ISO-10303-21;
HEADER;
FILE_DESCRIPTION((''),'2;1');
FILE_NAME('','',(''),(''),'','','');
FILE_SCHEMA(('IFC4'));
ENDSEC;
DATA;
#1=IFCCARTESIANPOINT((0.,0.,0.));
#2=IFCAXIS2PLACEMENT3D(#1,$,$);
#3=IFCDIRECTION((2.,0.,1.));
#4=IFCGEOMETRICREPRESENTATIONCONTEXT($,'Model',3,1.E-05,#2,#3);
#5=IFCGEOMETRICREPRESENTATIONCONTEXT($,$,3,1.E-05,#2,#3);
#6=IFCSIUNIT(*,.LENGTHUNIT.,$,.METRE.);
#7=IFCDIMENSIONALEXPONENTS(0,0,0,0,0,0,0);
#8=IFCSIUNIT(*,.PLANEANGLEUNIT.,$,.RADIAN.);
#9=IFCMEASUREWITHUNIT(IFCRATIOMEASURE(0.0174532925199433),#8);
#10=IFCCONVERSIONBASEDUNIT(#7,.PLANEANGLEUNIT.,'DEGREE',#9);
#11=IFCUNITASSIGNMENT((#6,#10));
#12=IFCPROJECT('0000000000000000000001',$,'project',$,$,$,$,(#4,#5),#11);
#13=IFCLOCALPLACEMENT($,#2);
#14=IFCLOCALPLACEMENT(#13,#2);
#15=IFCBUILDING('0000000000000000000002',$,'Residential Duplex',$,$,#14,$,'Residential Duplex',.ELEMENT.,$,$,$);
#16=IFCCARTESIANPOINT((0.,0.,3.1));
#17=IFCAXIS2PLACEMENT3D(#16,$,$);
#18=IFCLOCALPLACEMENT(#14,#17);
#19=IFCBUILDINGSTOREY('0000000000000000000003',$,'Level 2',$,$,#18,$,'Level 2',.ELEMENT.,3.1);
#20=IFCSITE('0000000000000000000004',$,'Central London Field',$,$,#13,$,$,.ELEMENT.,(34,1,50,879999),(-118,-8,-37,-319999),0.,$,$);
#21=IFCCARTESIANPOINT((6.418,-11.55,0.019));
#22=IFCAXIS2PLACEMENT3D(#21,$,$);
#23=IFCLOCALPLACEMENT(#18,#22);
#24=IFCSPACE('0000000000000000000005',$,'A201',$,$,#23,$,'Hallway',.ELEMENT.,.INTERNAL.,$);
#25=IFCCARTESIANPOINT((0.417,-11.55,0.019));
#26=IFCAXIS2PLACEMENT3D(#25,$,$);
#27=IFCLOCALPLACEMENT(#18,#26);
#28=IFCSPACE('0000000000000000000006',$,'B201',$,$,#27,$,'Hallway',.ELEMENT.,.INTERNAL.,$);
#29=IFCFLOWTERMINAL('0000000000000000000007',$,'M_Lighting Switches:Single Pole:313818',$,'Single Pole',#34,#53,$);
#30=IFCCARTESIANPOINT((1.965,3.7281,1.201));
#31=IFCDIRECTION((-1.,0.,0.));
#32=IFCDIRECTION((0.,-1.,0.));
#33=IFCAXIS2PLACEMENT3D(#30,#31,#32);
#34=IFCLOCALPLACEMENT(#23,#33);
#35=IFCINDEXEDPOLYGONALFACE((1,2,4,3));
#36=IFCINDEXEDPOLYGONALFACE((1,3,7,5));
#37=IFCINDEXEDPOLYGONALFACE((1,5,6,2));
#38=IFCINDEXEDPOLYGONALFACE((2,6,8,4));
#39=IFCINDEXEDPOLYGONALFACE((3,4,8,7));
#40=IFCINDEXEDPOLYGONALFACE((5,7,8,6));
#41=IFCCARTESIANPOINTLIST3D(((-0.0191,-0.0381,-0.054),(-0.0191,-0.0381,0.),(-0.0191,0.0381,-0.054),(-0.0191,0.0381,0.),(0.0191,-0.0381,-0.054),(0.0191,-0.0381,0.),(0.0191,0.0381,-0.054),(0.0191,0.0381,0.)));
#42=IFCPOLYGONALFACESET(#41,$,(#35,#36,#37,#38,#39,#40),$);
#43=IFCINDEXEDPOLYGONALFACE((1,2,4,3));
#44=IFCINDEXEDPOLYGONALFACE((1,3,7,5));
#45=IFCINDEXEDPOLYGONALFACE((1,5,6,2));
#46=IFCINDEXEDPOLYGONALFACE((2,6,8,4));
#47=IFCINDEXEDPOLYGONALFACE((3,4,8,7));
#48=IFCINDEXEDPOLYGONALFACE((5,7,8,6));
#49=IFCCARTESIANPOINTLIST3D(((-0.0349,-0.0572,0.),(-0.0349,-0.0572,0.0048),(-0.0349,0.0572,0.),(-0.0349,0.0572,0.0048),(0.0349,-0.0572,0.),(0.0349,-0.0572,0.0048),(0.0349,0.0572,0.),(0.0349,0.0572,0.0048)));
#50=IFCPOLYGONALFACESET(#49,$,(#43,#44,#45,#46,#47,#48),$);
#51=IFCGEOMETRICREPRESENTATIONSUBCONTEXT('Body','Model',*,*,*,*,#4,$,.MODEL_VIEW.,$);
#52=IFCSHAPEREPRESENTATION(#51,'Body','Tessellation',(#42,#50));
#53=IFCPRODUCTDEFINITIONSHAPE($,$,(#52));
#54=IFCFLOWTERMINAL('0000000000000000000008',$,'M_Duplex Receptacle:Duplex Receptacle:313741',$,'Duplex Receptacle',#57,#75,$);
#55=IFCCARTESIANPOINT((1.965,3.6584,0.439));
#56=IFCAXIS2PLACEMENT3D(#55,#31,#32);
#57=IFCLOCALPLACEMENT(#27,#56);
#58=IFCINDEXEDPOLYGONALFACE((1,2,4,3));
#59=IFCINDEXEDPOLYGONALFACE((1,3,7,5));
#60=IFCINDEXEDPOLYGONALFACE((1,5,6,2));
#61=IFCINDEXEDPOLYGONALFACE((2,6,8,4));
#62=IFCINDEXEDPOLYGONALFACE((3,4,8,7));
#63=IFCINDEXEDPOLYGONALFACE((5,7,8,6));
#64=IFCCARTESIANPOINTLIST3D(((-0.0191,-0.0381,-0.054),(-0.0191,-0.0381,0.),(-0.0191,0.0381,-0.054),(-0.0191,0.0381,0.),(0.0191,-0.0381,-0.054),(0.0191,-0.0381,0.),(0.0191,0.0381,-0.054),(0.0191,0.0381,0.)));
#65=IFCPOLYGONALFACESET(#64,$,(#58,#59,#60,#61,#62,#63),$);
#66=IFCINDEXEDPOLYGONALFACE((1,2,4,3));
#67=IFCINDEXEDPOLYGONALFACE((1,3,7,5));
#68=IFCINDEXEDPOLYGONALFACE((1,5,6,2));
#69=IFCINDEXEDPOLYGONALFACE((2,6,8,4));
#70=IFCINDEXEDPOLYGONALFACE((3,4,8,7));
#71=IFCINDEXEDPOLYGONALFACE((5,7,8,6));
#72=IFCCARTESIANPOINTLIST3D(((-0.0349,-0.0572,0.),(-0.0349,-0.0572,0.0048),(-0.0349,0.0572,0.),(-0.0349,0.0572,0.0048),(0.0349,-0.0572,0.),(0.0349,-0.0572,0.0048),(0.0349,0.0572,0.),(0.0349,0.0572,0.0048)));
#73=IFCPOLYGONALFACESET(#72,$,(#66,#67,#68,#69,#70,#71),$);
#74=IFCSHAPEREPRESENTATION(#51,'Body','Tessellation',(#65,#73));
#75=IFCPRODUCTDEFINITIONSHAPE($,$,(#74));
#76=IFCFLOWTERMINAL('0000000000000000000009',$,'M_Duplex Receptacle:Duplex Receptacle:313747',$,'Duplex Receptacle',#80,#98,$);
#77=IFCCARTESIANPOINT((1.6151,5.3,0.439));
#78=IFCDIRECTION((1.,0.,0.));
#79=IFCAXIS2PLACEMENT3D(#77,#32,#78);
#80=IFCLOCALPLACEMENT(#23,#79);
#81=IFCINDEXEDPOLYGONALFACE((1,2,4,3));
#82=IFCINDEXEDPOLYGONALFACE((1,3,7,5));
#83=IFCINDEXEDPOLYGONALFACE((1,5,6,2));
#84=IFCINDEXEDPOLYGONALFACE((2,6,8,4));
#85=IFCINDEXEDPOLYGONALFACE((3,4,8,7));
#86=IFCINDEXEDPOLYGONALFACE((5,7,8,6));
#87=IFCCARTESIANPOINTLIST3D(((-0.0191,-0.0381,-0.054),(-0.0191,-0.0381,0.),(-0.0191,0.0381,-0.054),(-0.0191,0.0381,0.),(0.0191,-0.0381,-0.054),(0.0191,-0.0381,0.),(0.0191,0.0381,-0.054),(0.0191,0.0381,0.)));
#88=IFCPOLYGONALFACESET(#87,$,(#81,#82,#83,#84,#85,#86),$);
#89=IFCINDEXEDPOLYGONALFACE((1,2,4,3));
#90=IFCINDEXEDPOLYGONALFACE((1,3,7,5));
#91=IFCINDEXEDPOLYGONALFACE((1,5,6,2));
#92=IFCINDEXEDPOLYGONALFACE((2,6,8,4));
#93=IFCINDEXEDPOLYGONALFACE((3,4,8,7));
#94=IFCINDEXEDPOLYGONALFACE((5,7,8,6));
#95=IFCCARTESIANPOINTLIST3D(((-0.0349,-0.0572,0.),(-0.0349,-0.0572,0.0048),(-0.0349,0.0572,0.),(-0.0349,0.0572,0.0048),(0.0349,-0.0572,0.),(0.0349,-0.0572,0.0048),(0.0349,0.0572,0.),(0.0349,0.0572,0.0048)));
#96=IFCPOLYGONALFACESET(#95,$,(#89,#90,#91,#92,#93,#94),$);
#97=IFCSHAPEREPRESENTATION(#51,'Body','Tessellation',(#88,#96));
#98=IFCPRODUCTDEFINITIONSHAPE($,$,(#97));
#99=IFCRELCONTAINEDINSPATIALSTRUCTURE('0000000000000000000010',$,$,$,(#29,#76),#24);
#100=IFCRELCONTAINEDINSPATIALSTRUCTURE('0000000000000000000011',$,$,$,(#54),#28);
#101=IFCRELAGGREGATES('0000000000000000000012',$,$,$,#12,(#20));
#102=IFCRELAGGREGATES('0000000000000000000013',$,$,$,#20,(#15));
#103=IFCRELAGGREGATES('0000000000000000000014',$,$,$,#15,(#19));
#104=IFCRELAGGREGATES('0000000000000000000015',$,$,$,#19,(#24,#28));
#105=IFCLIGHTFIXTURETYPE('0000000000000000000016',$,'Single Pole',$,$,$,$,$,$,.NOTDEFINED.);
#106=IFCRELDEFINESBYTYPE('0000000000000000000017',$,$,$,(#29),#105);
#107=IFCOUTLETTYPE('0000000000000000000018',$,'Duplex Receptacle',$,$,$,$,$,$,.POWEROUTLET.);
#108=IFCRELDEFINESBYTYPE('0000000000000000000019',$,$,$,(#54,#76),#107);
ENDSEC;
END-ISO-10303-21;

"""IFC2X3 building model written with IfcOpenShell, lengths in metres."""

from ifc_helpers import new_model, entity, si_unit, converted_unit, direction, frame, frame_2d, origin, origin_2d_with_axis, place, context, subcontext, project, spatial, rectangle, extrude, source, transform, mapped, type_object, type_shapes, element, save


model = new_model("IFC2X3")

# Units and contexts
model_context = context("Model", 3, precision=1e-05, world=origin(), true_north=direction((2.0, 0.0, 1.0)))
context_of_model = context(None, 3, precision=1e-05, world=origin(), true_north=direction((2.0, 0.0, 1.0)))
body_context = subcontext(model_context, "Body", "Model", "MODEL_VIEW")
ifc_project = project(units=[si_unit("LENGTHUNIT", "METRE"), converted_unit("PLANEANGLEUNIT", "DEGREE", entity("IfcRatioMeasure", 0.0174532925199433), si_unit("PLANEANGLEUNIT", "RADIAN"), dimensions=[0, 0, 0, 0, 0, 0, 0])], contexts=[model_context, context_of_model])

# Site, building, storey
site_placement = place(None, origin())
site = spatial("IfcSite", under=ifc_project, at=site_placement, Name="Central London Field", CompositionType="ELEMENT", RefLatitude=(34, 1, 50, 879999), RefLongitude=(-118, -8, -37, -319999), RefElevation=0.0)
building_placement = place(site_placement, origin())
building = spatial("IfcBuilding", under=site, at=building_placement, Name="Residential Duplex", LongName="Residential Duplex", CompositionType="ELEMENT")
storey_placement = place(building_placement, frame((0.0, 0.0, 3.1)))
storey = spatial("IfcBuildingStorey", under=building, at=storey_placement, Name="Level 2", LongName="Level 2", CompositionType="ELEMENT", Elevation=3.1)

# Shared definitions
light_fixture_type = type_object("IfcLightFixtureType", Name="Single Pole", PredefinedType="NOTDEFINED")
shared_shape_1 = source(origin(), body_context, "Body", "SweptSolid", [
    extrude(rectangle(XDim=0.0381, YDim=0.0762, at=origin_2d_with_axis()), frame((0.0, 0.0, -0.054), z_axis=(0.0, 0.0, 1.0), x_axis=(-1.0, 0.0, 0.0)), (0.0, 0.0, 1.0), 0.054),
    extrude(rectangle(XDim=0.0698, YDim=0.1143, at=frame_2d((0.0, 0.0), x_axis=(1.0, 0.0))), frame((0.0, 0.0, 0.0), z_axis=(0.0, 0.0, 1.0), x_axis=(-1.0, 0.0, 0.0)), (0.0, 0.0, 1.0), 0.0048),
])
type_shapes(light_fixture_type, [shared_shape_1])

# Shared definitions
space_1_placement = place(storey_placement, frame((6.418, -11.55, 0.019)))
space_1 = spatial("IfcSpace", under=storey, at=space_1_placement, Name="A201", LongName="Hallway", CompositionType="ELEMENT", InteriorOrExteriorSpace="INTERNAL")

# Flow terminal
flow_terminal_1_placement = place(space_1_placement, frame((1.965, 3.7281, 1.201), z_axis=(-1.0, 0.0, 0.0), x_axis=(0.0, -1.0, 0.0)))
element("IfcFlowTerminal", 1, at=flow_terminal_1_placement, inside=space_1, type_object=light_fixture_type, Name="M_Lighting Switches:Single Pole:313818", ObjectType="Single Pole", context=body_context, shape_type="MappedRepresentation", body=[
    mapped(shared_shape_1, transform((0.0, 0.0, 0.0), scale=1.0)),
])

# Shared definitions
space_2_placement = place(storey_placement, frame((0.417, -11.55, 0.019)))
space_2 = spatial("IfcSpace", under=storey, at=space_2_placement, Name="B201", LongName="Hallway", CompositionType="ELEMENT", InteriorOrExteriorSpace="INTERNAL")

# Flow terminals
outlet_type = type_object("IfcOutletType", Name="Duplex Receptacle", PredefinedType="POWEROUTLET")
shared_shape_2 = source(origin(), body_context, "Body", "SweptSolid", [
    extrude(rectangle(XDim=0.0381, YDim=0.0762, at=origin_2d_with_axis()), frame((0.0, 0.0, -0.054), z_axis=(0.0, 0.0, 1.0), x_axis=(-1.0, 0.0, 0.0)), (0.0, 0.0, 1.0), 0.054),
    extrude(rectangle(XDim=0.0698, YDim=0.1143, at=frame_2d((0.0, 0.0), x_axis=(1.0, 0.0))), frame((0.0, 0.0, 0.0), z_axis=(0.0, 0.0, 1.0), x_axis=(-1.0, 0.0, 0.0)), (0.0, 0.0, 1.0), 0.0048),
])
type_shapes(outlet_type, [shared_shape_2])
for number, where, z_axis, x_axis, name in (
    (2, (1.965, 3.6584, 0.439), (-1.0, 0.0, 0.0), (0.0, -1.0, 0.0), "M_Duplex Receptacle:Duplex Receptacle:313741"),
):
    element("IfcFlowTerminal", number, at=place(space_2_placement, frame(where, z_axis=z_axis, x_axis=x_axis)), inside=space_2, type_object=outlet_type, Name=name, ObjectType="Duplex Receptacle", context=body_context, shape_type="MappedRepresentation", body=[
        mapped(shared_shape_2, transform((0.0, 0.0, 0.0), scale=1.0)),
    ])
for number, where, z_axis, x_axis, name in (
    (3, (1.6151, 5.3, 0.439), (0.0, -1.0, 0.0), (1.0, 0.0, 0.0), "M_Duplex Receptacle:Duplex Receptacle:313747"),
):
    element("IfcFlowTerminal", number, at=place(space_1_placement, frame(where, z_axis=z_axis, x_axis=x_axis)), inside=space_1, type_object=outlet_type, Name=name, ObjectType="Duplex Receptacle", context=body_context, shape_type="MappedRepresentation", body=[
        mapped(shared_shape_2, transform((0.0, 0.0, 0.0), scale=1.0)),
    ])

save(model, "model.ifc")
